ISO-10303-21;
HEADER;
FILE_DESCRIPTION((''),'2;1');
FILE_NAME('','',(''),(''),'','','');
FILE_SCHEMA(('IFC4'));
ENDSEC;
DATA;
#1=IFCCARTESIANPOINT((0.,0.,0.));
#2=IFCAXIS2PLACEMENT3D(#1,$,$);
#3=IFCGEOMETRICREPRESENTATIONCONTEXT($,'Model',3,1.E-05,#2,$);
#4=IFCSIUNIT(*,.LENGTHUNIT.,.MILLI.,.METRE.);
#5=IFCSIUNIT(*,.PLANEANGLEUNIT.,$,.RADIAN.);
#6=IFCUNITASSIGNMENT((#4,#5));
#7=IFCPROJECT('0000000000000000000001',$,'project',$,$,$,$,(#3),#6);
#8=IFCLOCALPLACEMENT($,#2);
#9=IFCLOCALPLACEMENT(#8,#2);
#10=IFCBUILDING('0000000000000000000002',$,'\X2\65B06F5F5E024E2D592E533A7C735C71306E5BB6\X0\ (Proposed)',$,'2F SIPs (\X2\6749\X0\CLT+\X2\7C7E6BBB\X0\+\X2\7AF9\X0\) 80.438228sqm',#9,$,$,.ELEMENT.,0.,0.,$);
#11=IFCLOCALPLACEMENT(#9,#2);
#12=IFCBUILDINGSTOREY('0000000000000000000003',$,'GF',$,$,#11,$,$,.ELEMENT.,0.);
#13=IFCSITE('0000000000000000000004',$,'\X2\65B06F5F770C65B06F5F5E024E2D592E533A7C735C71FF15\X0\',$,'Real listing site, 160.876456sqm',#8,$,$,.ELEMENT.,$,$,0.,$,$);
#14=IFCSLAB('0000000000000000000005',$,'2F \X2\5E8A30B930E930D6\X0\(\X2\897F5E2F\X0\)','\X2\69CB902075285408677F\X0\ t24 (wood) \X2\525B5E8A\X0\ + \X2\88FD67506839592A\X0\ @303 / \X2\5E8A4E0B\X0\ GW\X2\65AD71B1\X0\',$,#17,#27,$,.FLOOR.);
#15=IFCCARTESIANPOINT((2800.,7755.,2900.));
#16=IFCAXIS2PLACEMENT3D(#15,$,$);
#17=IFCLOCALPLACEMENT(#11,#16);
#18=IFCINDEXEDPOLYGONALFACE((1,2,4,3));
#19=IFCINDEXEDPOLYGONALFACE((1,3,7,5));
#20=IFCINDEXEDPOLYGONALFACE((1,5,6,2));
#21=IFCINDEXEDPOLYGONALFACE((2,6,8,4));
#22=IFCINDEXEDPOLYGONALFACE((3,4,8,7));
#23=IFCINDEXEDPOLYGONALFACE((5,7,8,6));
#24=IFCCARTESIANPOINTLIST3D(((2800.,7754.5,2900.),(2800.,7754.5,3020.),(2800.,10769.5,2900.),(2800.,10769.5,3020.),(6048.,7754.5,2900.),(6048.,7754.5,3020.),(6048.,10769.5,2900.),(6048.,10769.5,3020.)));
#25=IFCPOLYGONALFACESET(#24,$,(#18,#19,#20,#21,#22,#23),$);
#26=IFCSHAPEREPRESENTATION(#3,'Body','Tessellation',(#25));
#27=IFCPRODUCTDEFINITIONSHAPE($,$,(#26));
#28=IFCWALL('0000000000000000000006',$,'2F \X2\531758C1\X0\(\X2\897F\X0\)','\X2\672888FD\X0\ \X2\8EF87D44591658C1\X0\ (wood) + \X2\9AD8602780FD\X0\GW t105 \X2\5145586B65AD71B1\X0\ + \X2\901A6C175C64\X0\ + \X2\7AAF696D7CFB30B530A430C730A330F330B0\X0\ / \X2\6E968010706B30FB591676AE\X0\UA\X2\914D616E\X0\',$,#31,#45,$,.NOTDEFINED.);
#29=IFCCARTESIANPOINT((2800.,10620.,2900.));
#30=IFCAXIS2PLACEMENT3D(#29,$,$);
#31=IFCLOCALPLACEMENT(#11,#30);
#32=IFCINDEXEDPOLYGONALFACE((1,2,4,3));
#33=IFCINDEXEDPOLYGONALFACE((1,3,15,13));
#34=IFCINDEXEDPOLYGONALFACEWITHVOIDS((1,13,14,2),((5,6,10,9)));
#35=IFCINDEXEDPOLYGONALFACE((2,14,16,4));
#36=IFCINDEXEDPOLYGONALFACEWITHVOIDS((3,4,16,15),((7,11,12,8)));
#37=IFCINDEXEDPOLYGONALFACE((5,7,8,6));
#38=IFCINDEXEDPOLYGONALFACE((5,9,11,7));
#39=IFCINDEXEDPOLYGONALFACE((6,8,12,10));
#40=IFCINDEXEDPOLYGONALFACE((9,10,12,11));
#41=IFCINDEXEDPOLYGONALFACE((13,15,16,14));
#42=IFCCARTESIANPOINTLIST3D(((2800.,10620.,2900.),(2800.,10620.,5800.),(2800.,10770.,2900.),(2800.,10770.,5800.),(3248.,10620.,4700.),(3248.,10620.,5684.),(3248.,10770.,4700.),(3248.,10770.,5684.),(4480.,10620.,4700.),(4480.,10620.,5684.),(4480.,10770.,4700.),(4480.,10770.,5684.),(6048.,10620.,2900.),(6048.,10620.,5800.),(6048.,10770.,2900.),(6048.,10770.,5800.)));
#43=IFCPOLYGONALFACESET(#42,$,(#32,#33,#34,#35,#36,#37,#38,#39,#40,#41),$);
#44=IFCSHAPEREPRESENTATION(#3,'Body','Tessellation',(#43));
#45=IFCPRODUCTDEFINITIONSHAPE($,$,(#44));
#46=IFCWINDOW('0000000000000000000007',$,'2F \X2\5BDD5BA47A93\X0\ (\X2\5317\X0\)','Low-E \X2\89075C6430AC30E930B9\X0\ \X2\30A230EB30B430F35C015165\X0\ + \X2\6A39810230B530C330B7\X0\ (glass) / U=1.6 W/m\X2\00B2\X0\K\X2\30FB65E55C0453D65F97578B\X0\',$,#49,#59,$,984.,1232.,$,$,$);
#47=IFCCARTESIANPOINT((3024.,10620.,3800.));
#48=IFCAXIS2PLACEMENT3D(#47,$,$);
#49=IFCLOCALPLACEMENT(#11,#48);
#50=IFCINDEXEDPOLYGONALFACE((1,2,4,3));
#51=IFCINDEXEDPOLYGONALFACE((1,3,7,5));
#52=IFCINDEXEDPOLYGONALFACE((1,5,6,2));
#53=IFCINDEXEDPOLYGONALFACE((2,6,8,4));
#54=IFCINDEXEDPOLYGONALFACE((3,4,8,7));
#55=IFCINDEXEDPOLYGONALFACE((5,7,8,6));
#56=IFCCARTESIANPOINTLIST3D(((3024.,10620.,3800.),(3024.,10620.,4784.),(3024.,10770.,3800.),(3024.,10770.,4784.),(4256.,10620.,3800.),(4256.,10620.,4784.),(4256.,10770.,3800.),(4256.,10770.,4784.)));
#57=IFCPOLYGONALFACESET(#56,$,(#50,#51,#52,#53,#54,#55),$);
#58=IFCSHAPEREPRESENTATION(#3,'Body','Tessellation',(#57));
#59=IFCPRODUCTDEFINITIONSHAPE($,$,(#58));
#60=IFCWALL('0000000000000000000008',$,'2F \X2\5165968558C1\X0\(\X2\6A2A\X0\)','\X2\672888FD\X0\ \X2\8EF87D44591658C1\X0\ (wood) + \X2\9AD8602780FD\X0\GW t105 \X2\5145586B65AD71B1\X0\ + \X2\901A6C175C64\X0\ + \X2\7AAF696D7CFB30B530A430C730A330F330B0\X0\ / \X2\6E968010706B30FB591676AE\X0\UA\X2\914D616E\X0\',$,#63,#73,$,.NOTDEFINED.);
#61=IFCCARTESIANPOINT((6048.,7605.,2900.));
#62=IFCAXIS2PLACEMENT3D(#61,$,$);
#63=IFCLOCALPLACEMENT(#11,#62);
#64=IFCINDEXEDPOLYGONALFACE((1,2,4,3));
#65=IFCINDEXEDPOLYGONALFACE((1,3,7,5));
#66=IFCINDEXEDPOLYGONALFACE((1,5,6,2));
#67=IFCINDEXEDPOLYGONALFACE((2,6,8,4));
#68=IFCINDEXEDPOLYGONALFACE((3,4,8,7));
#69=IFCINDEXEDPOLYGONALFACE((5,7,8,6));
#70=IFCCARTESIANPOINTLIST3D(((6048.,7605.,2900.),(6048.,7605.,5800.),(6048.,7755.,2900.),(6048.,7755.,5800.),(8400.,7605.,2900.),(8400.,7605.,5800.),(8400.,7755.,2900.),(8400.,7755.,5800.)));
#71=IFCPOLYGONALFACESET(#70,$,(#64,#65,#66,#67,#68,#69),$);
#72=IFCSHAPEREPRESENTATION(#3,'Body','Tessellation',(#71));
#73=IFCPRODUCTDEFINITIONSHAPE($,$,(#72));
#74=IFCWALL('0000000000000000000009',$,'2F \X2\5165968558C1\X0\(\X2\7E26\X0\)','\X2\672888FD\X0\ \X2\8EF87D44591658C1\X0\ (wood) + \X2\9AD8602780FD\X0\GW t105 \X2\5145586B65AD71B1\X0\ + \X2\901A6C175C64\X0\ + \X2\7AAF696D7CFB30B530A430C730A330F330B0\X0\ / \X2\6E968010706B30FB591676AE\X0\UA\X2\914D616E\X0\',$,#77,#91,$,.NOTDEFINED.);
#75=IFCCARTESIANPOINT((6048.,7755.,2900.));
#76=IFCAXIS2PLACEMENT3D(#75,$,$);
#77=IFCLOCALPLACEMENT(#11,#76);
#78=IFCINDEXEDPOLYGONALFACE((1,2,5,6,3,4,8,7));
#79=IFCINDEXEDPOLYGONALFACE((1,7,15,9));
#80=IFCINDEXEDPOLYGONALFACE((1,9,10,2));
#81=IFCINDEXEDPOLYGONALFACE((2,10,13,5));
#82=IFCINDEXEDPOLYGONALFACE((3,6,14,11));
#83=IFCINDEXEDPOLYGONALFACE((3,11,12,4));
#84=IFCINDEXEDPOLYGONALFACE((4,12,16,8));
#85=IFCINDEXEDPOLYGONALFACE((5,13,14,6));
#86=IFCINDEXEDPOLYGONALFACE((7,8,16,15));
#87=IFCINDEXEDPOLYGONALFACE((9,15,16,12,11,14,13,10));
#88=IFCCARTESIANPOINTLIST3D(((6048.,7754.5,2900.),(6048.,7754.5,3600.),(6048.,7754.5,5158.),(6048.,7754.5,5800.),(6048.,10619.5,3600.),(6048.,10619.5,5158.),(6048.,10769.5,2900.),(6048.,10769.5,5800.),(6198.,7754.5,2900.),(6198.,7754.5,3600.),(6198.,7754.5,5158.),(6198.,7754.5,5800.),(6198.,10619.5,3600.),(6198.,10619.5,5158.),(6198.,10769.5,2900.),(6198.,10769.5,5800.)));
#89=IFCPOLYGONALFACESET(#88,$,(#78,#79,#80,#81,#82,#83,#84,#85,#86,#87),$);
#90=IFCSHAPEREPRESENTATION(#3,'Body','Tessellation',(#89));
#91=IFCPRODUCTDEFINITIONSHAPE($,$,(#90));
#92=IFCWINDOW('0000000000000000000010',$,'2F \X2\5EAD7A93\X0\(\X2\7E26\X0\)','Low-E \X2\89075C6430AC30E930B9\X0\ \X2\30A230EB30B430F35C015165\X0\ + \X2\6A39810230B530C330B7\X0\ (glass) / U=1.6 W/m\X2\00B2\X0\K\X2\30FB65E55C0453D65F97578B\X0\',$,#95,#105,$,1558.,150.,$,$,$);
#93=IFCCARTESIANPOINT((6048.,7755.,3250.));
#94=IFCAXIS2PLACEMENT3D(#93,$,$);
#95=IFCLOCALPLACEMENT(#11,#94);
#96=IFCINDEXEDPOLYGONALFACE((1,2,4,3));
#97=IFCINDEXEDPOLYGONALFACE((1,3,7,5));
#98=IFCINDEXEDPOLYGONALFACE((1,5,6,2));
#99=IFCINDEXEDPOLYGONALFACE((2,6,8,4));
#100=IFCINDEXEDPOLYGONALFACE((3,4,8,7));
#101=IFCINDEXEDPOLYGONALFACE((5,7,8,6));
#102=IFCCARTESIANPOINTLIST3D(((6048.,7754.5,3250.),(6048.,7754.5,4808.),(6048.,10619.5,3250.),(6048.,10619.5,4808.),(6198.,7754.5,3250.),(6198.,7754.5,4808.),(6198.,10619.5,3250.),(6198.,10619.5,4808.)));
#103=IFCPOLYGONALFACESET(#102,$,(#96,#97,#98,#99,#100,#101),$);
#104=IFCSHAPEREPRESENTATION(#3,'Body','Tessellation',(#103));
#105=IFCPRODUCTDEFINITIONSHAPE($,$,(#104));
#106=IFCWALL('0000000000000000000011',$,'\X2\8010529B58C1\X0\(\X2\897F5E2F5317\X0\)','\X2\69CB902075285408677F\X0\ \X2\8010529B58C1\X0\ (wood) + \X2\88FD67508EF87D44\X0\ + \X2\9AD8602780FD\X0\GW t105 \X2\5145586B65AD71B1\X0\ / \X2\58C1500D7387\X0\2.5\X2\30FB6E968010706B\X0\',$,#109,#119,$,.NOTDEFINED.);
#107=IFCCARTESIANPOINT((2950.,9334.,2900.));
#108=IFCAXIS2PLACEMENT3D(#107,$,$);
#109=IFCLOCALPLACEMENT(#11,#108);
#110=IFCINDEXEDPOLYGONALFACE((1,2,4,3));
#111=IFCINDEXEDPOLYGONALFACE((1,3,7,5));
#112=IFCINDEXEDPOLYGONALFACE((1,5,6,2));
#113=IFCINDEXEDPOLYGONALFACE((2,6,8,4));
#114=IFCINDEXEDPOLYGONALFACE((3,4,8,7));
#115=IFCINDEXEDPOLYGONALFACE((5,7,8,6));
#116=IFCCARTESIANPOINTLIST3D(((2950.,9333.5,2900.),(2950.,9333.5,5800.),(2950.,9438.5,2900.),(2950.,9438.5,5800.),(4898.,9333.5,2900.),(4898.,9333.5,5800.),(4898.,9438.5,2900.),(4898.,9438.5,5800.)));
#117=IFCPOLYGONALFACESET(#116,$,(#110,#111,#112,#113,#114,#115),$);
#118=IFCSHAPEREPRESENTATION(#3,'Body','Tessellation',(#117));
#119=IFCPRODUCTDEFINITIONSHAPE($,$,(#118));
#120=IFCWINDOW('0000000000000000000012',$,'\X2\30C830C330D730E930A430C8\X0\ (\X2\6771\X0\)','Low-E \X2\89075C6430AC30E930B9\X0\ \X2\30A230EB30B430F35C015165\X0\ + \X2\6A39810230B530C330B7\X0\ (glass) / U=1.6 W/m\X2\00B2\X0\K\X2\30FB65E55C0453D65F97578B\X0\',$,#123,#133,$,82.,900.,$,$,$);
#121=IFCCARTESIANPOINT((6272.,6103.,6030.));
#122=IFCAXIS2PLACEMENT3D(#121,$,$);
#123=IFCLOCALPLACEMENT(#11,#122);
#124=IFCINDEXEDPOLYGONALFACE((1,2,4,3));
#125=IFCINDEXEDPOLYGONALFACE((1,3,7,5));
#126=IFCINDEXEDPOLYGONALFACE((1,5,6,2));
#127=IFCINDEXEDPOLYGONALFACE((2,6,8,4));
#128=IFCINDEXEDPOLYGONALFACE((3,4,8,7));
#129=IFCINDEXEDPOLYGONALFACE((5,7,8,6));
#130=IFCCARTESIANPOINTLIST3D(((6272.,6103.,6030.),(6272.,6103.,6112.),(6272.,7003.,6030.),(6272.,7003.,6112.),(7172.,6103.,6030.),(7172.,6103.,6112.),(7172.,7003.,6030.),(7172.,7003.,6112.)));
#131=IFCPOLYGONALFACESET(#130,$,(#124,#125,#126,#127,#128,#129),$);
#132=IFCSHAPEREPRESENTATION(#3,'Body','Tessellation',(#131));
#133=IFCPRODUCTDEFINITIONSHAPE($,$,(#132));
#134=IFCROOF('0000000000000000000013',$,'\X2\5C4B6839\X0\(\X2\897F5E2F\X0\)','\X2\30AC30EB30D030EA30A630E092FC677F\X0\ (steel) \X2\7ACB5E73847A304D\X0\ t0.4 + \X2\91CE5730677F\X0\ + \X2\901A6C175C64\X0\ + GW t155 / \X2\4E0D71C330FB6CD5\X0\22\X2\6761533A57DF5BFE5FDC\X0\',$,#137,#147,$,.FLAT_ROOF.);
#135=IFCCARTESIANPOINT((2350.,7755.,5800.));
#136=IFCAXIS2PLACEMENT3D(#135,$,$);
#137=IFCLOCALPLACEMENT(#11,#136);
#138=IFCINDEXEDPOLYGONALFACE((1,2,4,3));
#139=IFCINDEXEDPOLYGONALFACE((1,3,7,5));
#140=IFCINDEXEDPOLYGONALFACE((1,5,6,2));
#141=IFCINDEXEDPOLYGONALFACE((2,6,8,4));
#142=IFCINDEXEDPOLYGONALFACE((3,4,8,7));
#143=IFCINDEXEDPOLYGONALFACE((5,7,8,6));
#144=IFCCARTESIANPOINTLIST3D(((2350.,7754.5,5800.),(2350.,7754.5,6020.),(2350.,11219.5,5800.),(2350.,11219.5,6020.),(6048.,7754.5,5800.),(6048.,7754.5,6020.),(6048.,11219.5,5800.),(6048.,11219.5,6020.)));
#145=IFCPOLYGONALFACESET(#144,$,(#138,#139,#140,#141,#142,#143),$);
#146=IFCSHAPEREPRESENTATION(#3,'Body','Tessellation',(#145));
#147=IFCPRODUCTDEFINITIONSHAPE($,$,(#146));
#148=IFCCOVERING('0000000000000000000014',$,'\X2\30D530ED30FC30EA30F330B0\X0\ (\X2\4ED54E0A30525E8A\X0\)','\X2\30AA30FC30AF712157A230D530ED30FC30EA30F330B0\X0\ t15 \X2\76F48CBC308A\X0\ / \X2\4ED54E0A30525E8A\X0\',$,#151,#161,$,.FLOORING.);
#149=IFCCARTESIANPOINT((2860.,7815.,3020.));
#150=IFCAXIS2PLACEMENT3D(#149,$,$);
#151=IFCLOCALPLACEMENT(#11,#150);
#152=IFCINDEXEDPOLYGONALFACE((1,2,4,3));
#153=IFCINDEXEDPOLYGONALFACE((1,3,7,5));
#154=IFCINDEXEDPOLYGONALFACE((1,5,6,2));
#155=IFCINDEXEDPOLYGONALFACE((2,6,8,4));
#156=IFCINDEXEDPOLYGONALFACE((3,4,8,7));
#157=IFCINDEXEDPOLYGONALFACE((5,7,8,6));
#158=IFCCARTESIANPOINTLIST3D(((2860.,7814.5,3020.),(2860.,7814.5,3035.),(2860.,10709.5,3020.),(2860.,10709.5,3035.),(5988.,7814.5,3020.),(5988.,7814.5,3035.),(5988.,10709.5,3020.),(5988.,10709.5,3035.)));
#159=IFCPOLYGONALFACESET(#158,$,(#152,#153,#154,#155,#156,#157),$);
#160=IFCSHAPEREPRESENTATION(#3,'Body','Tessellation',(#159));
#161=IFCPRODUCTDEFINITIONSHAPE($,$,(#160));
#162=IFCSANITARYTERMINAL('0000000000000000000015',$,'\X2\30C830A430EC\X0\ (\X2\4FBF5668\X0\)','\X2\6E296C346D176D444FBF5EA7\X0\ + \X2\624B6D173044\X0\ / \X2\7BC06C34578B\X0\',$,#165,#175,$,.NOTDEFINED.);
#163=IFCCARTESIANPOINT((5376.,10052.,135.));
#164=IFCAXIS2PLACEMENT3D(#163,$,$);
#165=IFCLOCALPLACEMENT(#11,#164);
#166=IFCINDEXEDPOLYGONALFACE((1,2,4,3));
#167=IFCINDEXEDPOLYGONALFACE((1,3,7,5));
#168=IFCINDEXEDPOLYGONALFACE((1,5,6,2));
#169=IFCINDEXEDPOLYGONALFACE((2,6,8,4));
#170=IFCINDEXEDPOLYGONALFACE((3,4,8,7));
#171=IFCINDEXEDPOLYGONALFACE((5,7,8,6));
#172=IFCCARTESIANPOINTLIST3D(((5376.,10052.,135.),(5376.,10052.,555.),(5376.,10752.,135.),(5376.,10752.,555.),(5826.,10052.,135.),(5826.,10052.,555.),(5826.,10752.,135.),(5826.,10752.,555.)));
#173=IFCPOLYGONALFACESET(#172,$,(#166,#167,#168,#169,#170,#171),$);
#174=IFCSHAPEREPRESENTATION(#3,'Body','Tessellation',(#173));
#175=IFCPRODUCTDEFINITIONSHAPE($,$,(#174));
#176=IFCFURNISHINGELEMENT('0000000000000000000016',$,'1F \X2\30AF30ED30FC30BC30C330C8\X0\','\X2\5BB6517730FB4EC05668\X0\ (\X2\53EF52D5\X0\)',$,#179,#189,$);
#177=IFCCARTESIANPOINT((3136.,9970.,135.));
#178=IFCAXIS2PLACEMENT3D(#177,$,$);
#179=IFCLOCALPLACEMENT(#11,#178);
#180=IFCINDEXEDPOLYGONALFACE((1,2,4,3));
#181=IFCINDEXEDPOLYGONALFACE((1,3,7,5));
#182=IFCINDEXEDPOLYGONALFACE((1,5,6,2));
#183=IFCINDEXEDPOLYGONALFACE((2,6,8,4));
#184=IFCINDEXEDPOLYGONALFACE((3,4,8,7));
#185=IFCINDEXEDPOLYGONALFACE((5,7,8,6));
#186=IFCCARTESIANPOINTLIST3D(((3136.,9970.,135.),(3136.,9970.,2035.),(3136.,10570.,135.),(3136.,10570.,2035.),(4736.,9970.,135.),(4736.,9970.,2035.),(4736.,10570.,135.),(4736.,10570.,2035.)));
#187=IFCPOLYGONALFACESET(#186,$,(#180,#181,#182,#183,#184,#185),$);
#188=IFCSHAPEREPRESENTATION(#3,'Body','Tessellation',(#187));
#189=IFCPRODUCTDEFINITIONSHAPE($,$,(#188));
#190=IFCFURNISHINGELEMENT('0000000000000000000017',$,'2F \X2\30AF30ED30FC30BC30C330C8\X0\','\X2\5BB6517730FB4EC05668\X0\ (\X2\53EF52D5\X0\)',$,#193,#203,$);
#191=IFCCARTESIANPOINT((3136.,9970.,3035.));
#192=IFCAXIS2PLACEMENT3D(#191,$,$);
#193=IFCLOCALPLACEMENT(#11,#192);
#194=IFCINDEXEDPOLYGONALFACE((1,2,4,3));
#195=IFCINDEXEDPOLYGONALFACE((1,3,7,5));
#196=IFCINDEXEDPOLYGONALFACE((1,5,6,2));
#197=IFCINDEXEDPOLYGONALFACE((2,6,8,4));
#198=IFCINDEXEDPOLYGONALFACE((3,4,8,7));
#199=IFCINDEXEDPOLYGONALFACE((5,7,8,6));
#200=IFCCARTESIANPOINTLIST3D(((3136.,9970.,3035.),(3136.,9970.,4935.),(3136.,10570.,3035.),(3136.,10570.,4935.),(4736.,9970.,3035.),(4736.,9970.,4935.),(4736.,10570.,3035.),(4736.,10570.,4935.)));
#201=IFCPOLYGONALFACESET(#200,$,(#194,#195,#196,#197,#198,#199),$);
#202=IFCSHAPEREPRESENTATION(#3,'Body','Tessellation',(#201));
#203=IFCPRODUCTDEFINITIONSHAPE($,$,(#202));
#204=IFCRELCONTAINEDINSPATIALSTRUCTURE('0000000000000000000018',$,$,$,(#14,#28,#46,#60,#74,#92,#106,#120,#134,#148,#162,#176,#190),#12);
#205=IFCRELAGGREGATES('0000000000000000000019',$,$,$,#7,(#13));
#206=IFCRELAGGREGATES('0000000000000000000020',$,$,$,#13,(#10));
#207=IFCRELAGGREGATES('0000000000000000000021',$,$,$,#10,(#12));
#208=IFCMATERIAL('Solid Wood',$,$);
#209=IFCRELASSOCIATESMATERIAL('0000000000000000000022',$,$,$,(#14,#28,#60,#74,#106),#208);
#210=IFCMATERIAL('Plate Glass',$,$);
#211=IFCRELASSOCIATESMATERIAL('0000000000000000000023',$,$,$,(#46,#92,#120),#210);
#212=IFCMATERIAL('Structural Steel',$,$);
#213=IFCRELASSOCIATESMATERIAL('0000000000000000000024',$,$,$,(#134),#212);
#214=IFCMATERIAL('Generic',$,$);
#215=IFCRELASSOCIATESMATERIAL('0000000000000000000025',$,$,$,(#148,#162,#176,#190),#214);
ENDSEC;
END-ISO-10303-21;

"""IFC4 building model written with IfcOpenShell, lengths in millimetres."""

from ifc_helpers import new_model, si_unit, frame, frame_2d, origin, place, context, project, spatial, rectangle, extrude, material, element, fill, save


model = new_model("IFC4")

# Units and contexts
model_context = context("Model", 3, precision=1e-05, world=origin())
ifc_project = project(units=[si_unit("LENGTHUNIT", "METRE", prefix="MILLI"), si_unit("PLANEANGLEUNIT", "RADIAN")], contexts=[model_context])

# Site, building, storey
site_placement = place(None, origin())
site = spatial("IfcSite", under=ifc_project, at=site_placement, Name="新潟県新潟市中央区米山５", ObjectType="Real listing site, 160.876456sqm", CompositionType="ELEMENT", RefElevation=0.0)
building_placement = place(site_placement, origin())
building = spatial("IfcBuilding", under=site, at=building_placement, Name="新潟市中央区米山の家 (Proposed)", ObjectType="2F SIPs (杉CLT+籾殻+竹) 80.438228sqm", CompositionType="ELEMENT", ElevationOfRefHeight=0.0, ElevationOfTerrain=0.0)
storey_placement = place(building_placement, origin())
storey = spatial("IfcBuildingStorey", under=building, at=storey_placement, Name="GF", CompositionType="ELEMENT", Elevation=0.0)

# Slab
ifc_material_1 = material(Name="Solid Wood")
slab_placement = place(storey_placement, frame((2800.0, 7755.0, 2900.0)))
element("IfcSlab", 1, at=slab_placement, inside=storey, material=ifc_material_1, Name="2F 床スラブ(西帯)", Description="構造用合板 t24 (wood) 剛床 + 製材根太 @303 / 床下 GW断熱", PredefinedType="FLOOR", context=model_context, shape_type="SweptSolid", body=[
    extrude(rectangle(XDim=3248.0, YDim=3015.0, at=frame_2d((1624.0, 1507.0))), frame((2800.0, 7755.0, 2900.0)), (0.0, 0.0, 1.0), 120.0),
])

# Wall, opening, window
wall_1_placement = place(storey_placement, frame((2800.0, 10620.0, 2900.0)))
wall_1 = element("IfcWall", 2, at=wall_1_placement, inside=storey, material=ifc_material_1, Name="2F 北壁(西)", Description="木製 軸組外壁 (wood) + 高性能GW t105 充填断熱 + 通気層 + 窯業系サイディング / 準耐火・外皮UA配慮", PredefinedType="NOTDEFINED", context=model_context, shape_type="SweptSolid", body=[
    extrude(rectangle(XDim=3248.0, YDim=150.0, at=frame_2d((1624.0, 75.0))), frame((2800.0, 10620.0, 2900.0)), (0.0, 0.0, 1.0), 2900.0),
])
opening_1_placement = place(storey_placement, frame((3024.0, 10620.0, 3800.0)))
opening_1 = element("IfcOpeningElement", 3, at=opening_1_placement, cuts=wall_1, PredefinedType="NOTDEFINED", context=model_context, shape_type="SweptSolid", body=[
    extrude(rectangle(XDim=1232.0, YDim=150.0, at=frame_2d((616.0, 75.0))), frame((3024.0, 10620.0, 3800.0)), (0.0, 0.0, 1.0), 984.0),
])
ifc_material_2 = material(Name="Plate Glass")
window_1_placement = place(storey_placement, frame((3024.0, 10620.0, 3800.0)))
window_1 = element("IfcWindow", 4, at=window_1_placement, inside=storey, material=ifc_material_2, Name="2F 寝室窓 (北)", Description="Low-E 複層ガラス アルゴン封入 + 樹脂サッシ (glass) / U=1.6 W/m²K・日射取得型", OverallHeight=984.0, OverallWidth=1232.0, context=model_context, shape_type="SweptSolid", body=[
    extrude(rectangle(XDim=1232.0, YDim=150.0, at=frame_2d((616.0, 75.0))), frame((3024.0, 10620.0, 3800.0)), (0.0, 0.0, 1.0), 984.0),
])
fill(opening_1, window_1)

# Wall
wall_2_placement = place(storey_placement, frame((6048.0, 7605.0, 2900.0)))
element("IfcWall", 5, at=wall_2_placement, inside=storey, material=ifc_material_1, Name="2F 入隅壁(横)", Description="木製 軸組外壁 (wood) + 高性能GW t105 充填断熱 + 通気層 + 窯業系サイディング / 準耐火・外皮UA配慮", PredefinedType="NOTDEFINED", context=model_context, shape_type="SweptSolid", body=[
    extrude(rectangle(XDim=2352.0, YDim=150.0, at=frame_2d((1176.0, 75.0))), frame((6048.0, 7605.0, 2900.0)), (0.0, 0.0, 1.0), 2900.0),
])

# Wall, opening, window
wall_3_placement = place(storey_placement, frame((6048.0, 7755.0, 2900.0)))
wall_3 = element("IfcWall", 6, at=wall_3_placement, inside=storey, material=ifc_material_1, Name="2F 入隅壁(縦)", Description="木製 軸組外壁 (wood) + 高性能GW t105 充填断熱 + 通気層 + 窯業系サイディング / 準耐火・外皮UA配慮", PredefinedType="NOTDEFINED", context=model_context, shape_type="SweptSolid", body=[
    extrude(rectangle(XDim=150.0, YDim=3015.0, at=frame_2d((75.0, 1507.0))), frame((6048.0, 7755.0, 2900.0)), (0.0, 0.0, 1.0), 2900.0),
])
opening_2_placement = place(storey_placement, frame((6048.0, 7755.0, 3250.0)))
opening_2 = element("IfcOpeningElement", 7, at=opening_2_placement, cuts=wall_3, PredefinedType="NOTDEFINED", context=model_context, shape_type="SweptSolid", body=[
    extrude(rectangle(XDim=150.0, YDim=2865.0, at=frame_2d((75.0, 1432.0))), frame((6048.0, 7755.0, 3250.0)), (0.0, 0.0, 1.0), 1558.0),
])
window_2_placement = place(storey_placement, frame((6048.0, 7755.0, 3250.0)))
window_2 = element("IfcWindow", 8, at=window_2_placement, inside=storey, material=ifc_material_2, Name="2F 庭窓(縦)", Description="Low-E 複層ガラス アルゴン封入 + 樹脂サッシ (glass) / U=1.6 W/m²K・日射取得型", OverallHeight=1558.0, OverallWidth=150.0, context=model_context, shape_type="SweptSolid", body=[
    extrude(rectangle(XDim=150.0, YDim=2865.0, at=frame_2d((75.0, 1432.0))), frame((6048.0, 7755.0, 3250.0)), (0.0, 0.0, 1.0), 1558.0),
])
fill(opening_2, window_2)

# Wall
wall_4_placement = place(storey_placement, frame((2950.0, 9334.0, 2900.0)))
element("IfcWall", 9, at=wall_4_placement, inside=storey, material=ifc_material_1, Name="耐力壁(西帯北)", Description="構造用合板 耐力壁 (wood) + 製材軸組 + 高性能GW t105 充填断熱 / 壁倍率2.5・準耐火", PredefinedType="NOTDEFINED", context=model_context, shape_type="SweptSolid", body=[
    extrude(rectangle(XDim=1948.0, YDim=105.0, at=frame_2d((974.0, 52.0))), frame((2950.0, 9334.0, 2900.0)), (0.0, 0.0, 1.0), 2900.0),
])

# Window
window_3_placement = place(storey_placement, frame((6272.0, 6103.0, 6030.0)))
element("IfcWindow", 10, at=window_3_placement, inside=storey, material=ifc_material_2, Name="トップライト (東)", Description="Low-E 複層ガラス アルゴン封入 + 樹脂サッシ (glass) / U=1.6 W/m²K・日射取得型", OverallHeight=82.0, OverallWidth=900.0, context=model_context, shape_type="SweptSolid", body=[
    extrude(rectangle(XDim=900.0, YDim=900.0, at=frame_2d((450.0, 450.0))), frame((6272.0, 6103.0, 6030.0)), (0.0, 0.0, 1.0), 82.0),
])

# Roof
ifc_material_3 = material(Name="Structural Steel")
for number, where, name in (
    (11, (2350.0, 7755.0, 5800.0), "屋根(西帯)"),
):
    element("IfcRoof", number, at=place(storey_placement, frame(where)), inside=storey, material=ifc_material_3, Name=name, Description="ガルバリウム鋼板 (steel) 立平葺き t0.4 + 野地板 + 通気層 + GW t155 / 不燃・法22条区域対応", PredefinedType="FLAT_ROOF", context=model_context, shape_type="SweptSolid", body=[
        extrude(rectangle(XDim=3698.0, YDim=3465.0, at=frame_2d((1849.0, 1732.0))), frame((2350.0, 7755.0, 5800.0)), (0.0, 0.0, 1.0), 220.0),
    ])

# Covering
ifc_material_4 = material(Name="Generic")
covering_placement = place(storey_placement, frame((2860.0, 7815.0, 3020.0)))
element("IfcCovering", 12, at=covering_placement, inside=storey, material=ifc_material_4, Name="フローリング (仕上げ床)", Description="オーク無垢フローリング t15 直貼り / 仕上げ床", PredefinedType="FLOORING", context=model_context, shape_type="SweptSolid", body=[
    extrude(rectangle(XDim=3128.0, YDim=2895.0, at=frame_2d((1564.0, 1447.0))), frame((2860.0, 7815.0, 3020.0)), (0.0, 0.0, 1.0), 15.0),
])

# Sanitary terminal
sanitary_terminal_placement = place(storey_placement, frame((5376.0, 10052.0, 135.0)))
element("IfcSanitaryTerminal", 13, at=sanitary_terminal_placement, inside=storey, material=ifc_material_4, Name="トイレ (便器)", Description="温水洗浄便座 + 手洗い / 節水型", PredefinedType="NOTDEFINED", context=model_context, shape_type="SweptSolid", body=[
    extrude(rectangle(XDim=450.0, YDim=700.0, at=frame_2d((225.0, 350.0))), frame((5376.0, 10052.0, 135.0)), (0.0, 0.0, 1.0), 420.0),
])

# Furnishing elements
furnishing_1_placement = place(storey_placement, frame((3136.0, 9970.0, 135.0)))
element("IfcFurnishingElement", 14, at=furnishing_1_placement, inside=storey, material=ifc_material_4, Name="1F クローゼット", Description="家具・什器 (可動)", context=model_context, shape_type="SweptSolid", body=[
    extrude(rectangle(XDim=1600.0, YDim=600.0, at=frame_2d((800.0, 300.0))), frame((3136.0, 9970.0, 135.0)), (0.0, 0.0, 1.0), 1900.0),
])
furnishing_2_placement = place(storey_placement, frame((3136.0, 9970.0, 3035.0)))
element("IfcFurnishingElement", 15, at=furnishing_2_placement, inside=storey, material=ifc_material_4, Name="2F クローゼット", Description="家具・什器 (可動)", context=model_context, shape_type="SweptSolid", body=[
    extrude(rectangle(XDim=1600.0, YDim=600.0, at=frame_2d((800.0, 300.0))), frame((3136.0, 9970.0, 3035.0)), (0.0, 0.0, 1.0), 1900.0),
])

save(model, "model.ifc")
